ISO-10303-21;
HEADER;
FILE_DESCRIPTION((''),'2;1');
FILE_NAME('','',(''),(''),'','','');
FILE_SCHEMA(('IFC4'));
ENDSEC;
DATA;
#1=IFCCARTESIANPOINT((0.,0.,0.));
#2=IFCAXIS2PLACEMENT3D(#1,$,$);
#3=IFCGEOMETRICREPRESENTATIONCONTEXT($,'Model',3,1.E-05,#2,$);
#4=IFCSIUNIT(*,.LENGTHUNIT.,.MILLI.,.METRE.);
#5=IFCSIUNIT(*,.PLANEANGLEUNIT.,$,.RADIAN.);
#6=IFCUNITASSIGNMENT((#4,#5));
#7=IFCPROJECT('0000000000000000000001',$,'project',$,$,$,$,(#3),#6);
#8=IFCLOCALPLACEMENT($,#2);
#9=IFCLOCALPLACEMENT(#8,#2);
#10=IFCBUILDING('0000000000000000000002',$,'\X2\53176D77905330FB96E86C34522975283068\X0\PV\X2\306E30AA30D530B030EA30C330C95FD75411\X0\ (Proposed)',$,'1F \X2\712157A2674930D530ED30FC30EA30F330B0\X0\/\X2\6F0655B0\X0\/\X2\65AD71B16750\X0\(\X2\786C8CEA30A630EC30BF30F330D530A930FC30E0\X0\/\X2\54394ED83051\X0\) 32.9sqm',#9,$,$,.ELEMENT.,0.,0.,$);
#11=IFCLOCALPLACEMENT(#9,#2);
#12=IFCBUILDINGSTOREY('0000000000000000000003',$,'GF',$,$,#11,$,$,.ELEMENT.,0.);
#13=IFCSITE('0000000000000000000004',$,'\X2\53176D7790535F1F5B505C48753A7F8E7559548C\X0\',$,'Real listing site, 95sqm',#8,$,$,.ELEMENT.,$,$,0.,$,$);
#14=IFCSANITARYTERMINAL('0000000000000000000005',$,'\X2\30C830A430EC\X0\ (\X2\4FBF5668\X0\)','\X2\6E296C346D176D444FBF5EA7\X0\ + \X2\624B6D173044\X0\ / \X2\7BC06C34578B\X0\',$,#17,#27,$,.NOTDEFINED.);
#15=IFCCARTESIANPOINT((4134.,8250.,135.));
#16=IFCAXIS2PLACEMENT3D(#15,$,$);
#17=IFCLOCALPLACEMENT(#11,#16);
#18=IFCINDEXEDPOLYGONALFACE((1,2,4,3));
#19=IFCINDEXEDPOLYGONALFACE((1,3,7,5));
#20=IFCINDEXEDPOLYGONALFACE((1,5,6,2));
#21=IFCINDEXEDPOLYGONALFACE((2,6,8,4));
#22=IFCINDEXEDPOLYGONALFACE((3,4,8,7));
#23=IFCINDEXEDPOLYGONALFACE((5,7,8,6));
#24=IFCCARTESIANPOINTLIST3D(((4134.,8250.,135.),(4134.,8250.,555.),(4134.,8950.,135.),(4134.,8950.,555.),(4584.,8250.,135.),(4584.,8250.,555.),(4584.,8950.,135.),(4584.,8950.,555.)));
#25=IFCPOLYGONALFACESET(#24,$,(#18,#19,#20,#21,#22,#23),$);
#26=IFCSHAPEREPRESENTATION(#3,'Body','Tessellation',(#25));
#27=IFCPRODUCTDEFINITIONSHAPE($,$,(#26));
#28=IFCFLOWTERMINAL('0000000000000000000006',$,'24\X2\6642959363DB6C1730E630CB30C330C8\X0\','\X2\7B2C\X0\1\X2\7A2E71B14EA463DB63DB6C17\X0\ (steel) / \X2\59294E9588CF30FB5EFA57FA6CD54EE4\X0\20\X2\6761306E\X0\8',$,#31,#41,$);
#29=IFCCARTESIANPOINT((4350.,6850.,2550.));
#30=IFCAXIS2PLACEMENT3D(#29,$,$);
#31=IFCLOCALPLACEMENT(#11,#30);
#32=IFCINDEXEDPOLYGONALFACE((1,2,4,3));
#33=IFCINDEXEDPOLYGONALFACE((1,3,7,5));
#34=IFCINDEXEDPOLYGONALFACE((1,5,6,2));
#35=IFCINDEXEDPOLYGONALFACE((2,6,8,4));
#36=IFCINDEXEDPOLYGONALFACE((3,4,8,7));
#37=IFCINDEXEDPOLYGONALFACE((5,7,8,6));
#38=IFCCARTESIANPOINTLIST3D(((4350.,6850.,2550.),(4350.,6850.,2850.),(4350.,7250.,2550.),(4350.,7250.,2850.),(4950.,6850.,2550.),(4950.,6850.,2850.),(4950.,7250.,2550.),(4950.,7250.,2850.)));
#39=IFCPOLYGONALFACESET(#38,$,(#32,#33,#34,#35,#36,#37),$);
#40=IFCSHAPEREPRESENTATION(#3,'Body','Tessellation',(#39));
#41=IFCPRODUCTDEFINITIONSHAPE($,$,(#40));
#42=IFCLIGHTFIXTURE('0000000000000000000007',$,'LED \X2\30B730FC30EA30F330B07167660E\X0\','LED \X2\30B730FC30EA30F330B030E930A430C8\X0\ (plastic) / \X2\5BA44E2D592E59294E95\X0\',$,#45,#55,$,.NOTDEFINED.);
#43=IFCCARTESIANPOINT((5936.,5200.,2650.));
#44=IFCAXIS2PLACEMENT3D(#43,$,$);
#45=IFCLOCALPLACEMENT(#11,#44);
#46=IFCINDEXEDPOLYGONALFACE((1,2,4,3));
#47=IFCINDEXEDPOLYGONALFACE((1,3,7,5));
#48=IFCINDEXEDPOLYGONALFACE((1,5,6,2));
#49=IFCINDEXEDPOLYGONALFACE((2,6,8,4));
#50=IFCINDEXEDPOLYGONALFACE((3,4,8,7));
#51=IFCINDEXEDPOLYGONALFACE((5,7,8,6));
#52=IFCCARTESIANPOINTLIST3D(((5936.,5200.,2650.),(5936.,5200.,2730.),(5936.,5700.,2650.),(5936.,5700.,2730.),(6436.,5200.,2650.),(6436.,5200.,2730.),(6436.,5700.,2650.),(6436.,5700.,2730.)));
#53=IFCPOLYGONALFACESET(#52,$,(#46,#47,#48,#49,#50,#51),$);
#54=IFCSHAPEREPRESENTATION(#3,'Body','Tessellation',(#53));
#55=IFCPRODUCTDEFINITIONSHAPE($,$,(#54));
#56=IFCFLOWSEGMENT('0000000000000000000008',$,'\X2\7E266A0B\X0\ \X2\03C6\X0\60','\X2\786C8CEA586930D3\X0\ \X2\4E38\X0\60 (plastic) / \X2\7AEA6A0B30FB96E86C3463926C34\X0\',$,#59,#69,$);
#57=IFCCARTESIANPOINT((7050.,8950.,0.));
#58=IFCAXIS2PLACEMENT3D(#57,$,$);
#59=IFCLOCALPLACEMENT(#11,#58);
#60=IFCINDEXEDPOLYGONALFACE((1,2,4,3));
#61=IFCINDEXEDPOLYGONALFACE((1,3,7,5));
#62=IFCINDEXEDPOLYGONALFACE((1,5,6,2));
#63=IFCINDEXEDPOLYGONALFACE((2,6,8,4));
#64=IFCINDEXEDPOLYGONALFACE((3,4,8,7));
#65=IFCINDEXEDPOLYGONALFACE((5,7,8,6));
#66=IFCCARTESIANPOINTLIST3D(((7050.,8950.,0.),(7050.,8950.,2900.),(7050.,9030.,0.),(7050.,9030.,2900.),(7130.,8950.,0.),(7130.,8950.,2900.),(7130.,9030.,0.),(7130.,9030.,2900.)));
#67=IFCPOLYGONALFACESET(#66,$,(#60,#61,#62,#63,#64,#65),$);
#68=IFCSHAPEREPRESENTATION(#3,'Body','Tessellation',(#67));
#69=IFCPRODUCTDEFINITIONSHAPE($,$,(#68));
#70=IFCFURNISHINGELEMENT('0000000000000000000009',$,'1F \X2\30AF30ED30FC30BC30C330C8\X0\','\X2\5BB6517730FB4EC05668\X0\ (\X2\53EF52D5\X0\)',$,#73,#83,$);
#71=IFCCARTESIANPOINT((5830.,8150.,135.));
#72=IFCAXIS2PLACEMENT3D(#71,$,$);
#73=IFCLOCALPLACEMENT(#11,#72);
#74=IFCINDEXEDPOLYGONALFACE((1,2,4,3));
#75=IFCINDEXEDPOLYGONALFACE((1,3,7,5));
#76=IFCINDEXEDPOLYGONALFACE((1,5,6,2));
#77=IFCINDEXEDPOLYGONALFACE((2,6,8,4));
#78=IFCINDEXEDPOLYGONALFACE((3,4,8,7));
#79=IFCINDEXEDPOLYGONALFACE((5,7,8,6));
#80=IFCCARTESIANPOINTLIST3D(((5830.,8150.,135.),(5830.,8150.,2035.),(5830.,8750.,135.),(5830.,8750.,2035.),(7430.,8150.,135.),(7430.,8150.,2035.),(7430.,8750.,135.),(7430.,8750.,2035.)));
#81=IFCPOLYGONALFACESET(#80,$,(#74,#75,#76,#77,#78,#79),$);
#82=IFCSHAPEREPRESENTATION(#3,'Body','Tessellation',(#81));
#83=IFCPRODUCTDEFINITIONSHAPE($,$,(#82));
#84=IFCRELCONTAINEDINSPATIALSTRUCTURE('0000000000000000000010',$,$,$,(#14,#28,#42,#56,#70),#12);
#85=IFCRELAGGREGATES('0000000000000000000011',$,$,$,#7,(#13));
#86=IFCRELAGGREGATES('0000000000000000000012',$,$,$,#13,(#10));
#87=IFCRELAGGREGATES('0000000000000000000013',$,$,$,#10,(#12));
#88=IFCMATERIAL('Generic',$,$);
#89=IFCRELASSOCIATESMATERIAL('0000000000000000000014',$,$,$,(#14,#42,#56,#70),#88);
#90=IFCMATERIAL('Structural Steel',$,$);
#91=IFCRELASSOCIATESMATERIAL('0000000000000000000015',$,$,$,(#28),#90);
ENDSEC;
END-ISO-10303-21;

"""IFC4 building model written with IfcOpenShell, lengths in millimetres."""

from ifc_helpers import new_model, si_unit, frame, frame_2d, origin, place, context, project, spatial, rectangle, extrude, material, element, save


model = new_model("IFC4")

# Units and contexts
model_context = context("Model", 3, precision=1e-05, world=origin())
ifc_project = project(units=[si_unit("LENGTHUNIT", "METRE", prefix="MILLI"), si_unit("PLANEANGLEUNIT", "RADIAN")], contexts=[model_context])

# Site, building, storey
site_placement = place(None, origin())
site = spatial("IfcSite", under=ifc_project, at=site_placement, Name="北海道弟子屈町美留和", ObjectType="Real listing site, 95sqm", CompositionType="ELEMENT", RefElevation=0.0)
building_placement = place(site_placement, origin())
building = spatial("IfcBuilding", under=site, at=building_placement, Name="北海道・雨水利用とPVのオフグリッド志向 (Proposed)", ObjectType="1F 無垢杉フローリング/漆喰/断熱材(硬質ウレタンフォーム/吹付け) 32.9sqm", CompositionType="ELEMENT", ElevationOfRefHeight=0.0, ElevationOfTerrain=0.0)
storey_placement = place(building_placement, origin())
storey = spatial("IfcBuildingStorey", under=building, at=storey_placement, Name="GF", CompositionType="ELEMENT", Elevation=0.0)

# Shared definitions
ifc_material_1 = material(Name="Generic")

# Sanitary terminal
sanitary_terminal_placement = place(storey_placement, frame((4134.0, 8250.0, 135.0)))
element("IfcSanitaryTerminal", 1, at=sanitary_terminal_placement, inside=storey, material=ifc_material_1, Name="トイレ (便器)", Description="温水洗浄便座 + 手洗い / 節水型", PredefinedType="NOTDEFINED", context=model_context, shape_type="SweptSolid", body=[
    extrude(rectangle(XDim=450.0, YDim=700.0, at=frame_2d((225.0, 350.0))), frame((4134.0, 8250.0, 135.0)), (0.0, 0.0, 1.0), 420.0),
])

# Flow terminal
ifc_material_2 = material(Name="Structural Steel")
flow_terminal_placement = place(storey_placement, frame((4350.0, 6850.0, 2550.0)))
element("IfcFlowTerminal", 2, at=flow_terminal_placement, inside=storey, material=ifc_material_2, Name="24時間換気ユニット", Description="第1種熱交換換気 (steel) / 天井裏・建基法令20条の8", context=model_context, shape_type="SweptSolid", body=[
    extrude(rectangle(XDim=600.0, YDim=400.0, at=frame_2d((300.0, 200.0))), frame((4350.0, 6850.0, 2550.0)), (0.0, 0.0, 1.0), 300.0),
])

# Light fixture
light_fixture_placement = place(storey_placement, frame((5936.0, 5200.0, 2650.0)))
element("IfcLightFixture", 3, at=light_fixture_placement, inside=storey, material=ifc_material_1, Name="LED シーリング照明", Description="LED シーリングライト (plastic) / 室中央天井", PredefinedType="NOTDEFINED", context=model_context, shape_type="SweptSolid", body=[
    extrude(rectangle(XDim=500.0, YDim=500.0, at=frame_2d((250.0, 250.0))), frame((5936.0, 5200.0, 2650.0)), (0.0, 0.0, 1.0), 80.0),
])

# Flow segment
flow_segment_placement = place(storey_placement, frame((7050.0, 8950.0, 0.0)))
element("IfcFlowSegment", 4, at=flow_segment_placement, inside=storey, material=ifc_material_1, Name="縦樋 φ60", Description="硬質塩ビ 丸60 (plastic) / 竪樋・雨水排水", context=model_context, shape_type="SweptSolid", body=[
    extrude(rectangle(XDim=80.0, YDim=80.0, at=frame_2d((40.0, 40.0))), frame((7050.0, 8950.0, 0.0)), (0.0, 0.0, 1.0), 2900.0),
])

# Furnishing element
furnishing_placement = place(storey_placement, frame((5830.0, 8150.0, 135.0)))
element("IfcFurnishingElement", 5, at=furnishing_placement, inside=storey, material=ifc_material_1, Name="1F クローゼット", Description="家具・什器 (可動)", context=model_context, shape_type="SweptSolid", body=[
    extrude(rectangle(XDim=1600.0, YDim=600.0, at=frame_2d((800.0, 300.0))), frame((5830.0, 8150.0, 135.0)), (0.0, 0.0, 1.0), 1900.0),
])

save(model, "model.ifc")
